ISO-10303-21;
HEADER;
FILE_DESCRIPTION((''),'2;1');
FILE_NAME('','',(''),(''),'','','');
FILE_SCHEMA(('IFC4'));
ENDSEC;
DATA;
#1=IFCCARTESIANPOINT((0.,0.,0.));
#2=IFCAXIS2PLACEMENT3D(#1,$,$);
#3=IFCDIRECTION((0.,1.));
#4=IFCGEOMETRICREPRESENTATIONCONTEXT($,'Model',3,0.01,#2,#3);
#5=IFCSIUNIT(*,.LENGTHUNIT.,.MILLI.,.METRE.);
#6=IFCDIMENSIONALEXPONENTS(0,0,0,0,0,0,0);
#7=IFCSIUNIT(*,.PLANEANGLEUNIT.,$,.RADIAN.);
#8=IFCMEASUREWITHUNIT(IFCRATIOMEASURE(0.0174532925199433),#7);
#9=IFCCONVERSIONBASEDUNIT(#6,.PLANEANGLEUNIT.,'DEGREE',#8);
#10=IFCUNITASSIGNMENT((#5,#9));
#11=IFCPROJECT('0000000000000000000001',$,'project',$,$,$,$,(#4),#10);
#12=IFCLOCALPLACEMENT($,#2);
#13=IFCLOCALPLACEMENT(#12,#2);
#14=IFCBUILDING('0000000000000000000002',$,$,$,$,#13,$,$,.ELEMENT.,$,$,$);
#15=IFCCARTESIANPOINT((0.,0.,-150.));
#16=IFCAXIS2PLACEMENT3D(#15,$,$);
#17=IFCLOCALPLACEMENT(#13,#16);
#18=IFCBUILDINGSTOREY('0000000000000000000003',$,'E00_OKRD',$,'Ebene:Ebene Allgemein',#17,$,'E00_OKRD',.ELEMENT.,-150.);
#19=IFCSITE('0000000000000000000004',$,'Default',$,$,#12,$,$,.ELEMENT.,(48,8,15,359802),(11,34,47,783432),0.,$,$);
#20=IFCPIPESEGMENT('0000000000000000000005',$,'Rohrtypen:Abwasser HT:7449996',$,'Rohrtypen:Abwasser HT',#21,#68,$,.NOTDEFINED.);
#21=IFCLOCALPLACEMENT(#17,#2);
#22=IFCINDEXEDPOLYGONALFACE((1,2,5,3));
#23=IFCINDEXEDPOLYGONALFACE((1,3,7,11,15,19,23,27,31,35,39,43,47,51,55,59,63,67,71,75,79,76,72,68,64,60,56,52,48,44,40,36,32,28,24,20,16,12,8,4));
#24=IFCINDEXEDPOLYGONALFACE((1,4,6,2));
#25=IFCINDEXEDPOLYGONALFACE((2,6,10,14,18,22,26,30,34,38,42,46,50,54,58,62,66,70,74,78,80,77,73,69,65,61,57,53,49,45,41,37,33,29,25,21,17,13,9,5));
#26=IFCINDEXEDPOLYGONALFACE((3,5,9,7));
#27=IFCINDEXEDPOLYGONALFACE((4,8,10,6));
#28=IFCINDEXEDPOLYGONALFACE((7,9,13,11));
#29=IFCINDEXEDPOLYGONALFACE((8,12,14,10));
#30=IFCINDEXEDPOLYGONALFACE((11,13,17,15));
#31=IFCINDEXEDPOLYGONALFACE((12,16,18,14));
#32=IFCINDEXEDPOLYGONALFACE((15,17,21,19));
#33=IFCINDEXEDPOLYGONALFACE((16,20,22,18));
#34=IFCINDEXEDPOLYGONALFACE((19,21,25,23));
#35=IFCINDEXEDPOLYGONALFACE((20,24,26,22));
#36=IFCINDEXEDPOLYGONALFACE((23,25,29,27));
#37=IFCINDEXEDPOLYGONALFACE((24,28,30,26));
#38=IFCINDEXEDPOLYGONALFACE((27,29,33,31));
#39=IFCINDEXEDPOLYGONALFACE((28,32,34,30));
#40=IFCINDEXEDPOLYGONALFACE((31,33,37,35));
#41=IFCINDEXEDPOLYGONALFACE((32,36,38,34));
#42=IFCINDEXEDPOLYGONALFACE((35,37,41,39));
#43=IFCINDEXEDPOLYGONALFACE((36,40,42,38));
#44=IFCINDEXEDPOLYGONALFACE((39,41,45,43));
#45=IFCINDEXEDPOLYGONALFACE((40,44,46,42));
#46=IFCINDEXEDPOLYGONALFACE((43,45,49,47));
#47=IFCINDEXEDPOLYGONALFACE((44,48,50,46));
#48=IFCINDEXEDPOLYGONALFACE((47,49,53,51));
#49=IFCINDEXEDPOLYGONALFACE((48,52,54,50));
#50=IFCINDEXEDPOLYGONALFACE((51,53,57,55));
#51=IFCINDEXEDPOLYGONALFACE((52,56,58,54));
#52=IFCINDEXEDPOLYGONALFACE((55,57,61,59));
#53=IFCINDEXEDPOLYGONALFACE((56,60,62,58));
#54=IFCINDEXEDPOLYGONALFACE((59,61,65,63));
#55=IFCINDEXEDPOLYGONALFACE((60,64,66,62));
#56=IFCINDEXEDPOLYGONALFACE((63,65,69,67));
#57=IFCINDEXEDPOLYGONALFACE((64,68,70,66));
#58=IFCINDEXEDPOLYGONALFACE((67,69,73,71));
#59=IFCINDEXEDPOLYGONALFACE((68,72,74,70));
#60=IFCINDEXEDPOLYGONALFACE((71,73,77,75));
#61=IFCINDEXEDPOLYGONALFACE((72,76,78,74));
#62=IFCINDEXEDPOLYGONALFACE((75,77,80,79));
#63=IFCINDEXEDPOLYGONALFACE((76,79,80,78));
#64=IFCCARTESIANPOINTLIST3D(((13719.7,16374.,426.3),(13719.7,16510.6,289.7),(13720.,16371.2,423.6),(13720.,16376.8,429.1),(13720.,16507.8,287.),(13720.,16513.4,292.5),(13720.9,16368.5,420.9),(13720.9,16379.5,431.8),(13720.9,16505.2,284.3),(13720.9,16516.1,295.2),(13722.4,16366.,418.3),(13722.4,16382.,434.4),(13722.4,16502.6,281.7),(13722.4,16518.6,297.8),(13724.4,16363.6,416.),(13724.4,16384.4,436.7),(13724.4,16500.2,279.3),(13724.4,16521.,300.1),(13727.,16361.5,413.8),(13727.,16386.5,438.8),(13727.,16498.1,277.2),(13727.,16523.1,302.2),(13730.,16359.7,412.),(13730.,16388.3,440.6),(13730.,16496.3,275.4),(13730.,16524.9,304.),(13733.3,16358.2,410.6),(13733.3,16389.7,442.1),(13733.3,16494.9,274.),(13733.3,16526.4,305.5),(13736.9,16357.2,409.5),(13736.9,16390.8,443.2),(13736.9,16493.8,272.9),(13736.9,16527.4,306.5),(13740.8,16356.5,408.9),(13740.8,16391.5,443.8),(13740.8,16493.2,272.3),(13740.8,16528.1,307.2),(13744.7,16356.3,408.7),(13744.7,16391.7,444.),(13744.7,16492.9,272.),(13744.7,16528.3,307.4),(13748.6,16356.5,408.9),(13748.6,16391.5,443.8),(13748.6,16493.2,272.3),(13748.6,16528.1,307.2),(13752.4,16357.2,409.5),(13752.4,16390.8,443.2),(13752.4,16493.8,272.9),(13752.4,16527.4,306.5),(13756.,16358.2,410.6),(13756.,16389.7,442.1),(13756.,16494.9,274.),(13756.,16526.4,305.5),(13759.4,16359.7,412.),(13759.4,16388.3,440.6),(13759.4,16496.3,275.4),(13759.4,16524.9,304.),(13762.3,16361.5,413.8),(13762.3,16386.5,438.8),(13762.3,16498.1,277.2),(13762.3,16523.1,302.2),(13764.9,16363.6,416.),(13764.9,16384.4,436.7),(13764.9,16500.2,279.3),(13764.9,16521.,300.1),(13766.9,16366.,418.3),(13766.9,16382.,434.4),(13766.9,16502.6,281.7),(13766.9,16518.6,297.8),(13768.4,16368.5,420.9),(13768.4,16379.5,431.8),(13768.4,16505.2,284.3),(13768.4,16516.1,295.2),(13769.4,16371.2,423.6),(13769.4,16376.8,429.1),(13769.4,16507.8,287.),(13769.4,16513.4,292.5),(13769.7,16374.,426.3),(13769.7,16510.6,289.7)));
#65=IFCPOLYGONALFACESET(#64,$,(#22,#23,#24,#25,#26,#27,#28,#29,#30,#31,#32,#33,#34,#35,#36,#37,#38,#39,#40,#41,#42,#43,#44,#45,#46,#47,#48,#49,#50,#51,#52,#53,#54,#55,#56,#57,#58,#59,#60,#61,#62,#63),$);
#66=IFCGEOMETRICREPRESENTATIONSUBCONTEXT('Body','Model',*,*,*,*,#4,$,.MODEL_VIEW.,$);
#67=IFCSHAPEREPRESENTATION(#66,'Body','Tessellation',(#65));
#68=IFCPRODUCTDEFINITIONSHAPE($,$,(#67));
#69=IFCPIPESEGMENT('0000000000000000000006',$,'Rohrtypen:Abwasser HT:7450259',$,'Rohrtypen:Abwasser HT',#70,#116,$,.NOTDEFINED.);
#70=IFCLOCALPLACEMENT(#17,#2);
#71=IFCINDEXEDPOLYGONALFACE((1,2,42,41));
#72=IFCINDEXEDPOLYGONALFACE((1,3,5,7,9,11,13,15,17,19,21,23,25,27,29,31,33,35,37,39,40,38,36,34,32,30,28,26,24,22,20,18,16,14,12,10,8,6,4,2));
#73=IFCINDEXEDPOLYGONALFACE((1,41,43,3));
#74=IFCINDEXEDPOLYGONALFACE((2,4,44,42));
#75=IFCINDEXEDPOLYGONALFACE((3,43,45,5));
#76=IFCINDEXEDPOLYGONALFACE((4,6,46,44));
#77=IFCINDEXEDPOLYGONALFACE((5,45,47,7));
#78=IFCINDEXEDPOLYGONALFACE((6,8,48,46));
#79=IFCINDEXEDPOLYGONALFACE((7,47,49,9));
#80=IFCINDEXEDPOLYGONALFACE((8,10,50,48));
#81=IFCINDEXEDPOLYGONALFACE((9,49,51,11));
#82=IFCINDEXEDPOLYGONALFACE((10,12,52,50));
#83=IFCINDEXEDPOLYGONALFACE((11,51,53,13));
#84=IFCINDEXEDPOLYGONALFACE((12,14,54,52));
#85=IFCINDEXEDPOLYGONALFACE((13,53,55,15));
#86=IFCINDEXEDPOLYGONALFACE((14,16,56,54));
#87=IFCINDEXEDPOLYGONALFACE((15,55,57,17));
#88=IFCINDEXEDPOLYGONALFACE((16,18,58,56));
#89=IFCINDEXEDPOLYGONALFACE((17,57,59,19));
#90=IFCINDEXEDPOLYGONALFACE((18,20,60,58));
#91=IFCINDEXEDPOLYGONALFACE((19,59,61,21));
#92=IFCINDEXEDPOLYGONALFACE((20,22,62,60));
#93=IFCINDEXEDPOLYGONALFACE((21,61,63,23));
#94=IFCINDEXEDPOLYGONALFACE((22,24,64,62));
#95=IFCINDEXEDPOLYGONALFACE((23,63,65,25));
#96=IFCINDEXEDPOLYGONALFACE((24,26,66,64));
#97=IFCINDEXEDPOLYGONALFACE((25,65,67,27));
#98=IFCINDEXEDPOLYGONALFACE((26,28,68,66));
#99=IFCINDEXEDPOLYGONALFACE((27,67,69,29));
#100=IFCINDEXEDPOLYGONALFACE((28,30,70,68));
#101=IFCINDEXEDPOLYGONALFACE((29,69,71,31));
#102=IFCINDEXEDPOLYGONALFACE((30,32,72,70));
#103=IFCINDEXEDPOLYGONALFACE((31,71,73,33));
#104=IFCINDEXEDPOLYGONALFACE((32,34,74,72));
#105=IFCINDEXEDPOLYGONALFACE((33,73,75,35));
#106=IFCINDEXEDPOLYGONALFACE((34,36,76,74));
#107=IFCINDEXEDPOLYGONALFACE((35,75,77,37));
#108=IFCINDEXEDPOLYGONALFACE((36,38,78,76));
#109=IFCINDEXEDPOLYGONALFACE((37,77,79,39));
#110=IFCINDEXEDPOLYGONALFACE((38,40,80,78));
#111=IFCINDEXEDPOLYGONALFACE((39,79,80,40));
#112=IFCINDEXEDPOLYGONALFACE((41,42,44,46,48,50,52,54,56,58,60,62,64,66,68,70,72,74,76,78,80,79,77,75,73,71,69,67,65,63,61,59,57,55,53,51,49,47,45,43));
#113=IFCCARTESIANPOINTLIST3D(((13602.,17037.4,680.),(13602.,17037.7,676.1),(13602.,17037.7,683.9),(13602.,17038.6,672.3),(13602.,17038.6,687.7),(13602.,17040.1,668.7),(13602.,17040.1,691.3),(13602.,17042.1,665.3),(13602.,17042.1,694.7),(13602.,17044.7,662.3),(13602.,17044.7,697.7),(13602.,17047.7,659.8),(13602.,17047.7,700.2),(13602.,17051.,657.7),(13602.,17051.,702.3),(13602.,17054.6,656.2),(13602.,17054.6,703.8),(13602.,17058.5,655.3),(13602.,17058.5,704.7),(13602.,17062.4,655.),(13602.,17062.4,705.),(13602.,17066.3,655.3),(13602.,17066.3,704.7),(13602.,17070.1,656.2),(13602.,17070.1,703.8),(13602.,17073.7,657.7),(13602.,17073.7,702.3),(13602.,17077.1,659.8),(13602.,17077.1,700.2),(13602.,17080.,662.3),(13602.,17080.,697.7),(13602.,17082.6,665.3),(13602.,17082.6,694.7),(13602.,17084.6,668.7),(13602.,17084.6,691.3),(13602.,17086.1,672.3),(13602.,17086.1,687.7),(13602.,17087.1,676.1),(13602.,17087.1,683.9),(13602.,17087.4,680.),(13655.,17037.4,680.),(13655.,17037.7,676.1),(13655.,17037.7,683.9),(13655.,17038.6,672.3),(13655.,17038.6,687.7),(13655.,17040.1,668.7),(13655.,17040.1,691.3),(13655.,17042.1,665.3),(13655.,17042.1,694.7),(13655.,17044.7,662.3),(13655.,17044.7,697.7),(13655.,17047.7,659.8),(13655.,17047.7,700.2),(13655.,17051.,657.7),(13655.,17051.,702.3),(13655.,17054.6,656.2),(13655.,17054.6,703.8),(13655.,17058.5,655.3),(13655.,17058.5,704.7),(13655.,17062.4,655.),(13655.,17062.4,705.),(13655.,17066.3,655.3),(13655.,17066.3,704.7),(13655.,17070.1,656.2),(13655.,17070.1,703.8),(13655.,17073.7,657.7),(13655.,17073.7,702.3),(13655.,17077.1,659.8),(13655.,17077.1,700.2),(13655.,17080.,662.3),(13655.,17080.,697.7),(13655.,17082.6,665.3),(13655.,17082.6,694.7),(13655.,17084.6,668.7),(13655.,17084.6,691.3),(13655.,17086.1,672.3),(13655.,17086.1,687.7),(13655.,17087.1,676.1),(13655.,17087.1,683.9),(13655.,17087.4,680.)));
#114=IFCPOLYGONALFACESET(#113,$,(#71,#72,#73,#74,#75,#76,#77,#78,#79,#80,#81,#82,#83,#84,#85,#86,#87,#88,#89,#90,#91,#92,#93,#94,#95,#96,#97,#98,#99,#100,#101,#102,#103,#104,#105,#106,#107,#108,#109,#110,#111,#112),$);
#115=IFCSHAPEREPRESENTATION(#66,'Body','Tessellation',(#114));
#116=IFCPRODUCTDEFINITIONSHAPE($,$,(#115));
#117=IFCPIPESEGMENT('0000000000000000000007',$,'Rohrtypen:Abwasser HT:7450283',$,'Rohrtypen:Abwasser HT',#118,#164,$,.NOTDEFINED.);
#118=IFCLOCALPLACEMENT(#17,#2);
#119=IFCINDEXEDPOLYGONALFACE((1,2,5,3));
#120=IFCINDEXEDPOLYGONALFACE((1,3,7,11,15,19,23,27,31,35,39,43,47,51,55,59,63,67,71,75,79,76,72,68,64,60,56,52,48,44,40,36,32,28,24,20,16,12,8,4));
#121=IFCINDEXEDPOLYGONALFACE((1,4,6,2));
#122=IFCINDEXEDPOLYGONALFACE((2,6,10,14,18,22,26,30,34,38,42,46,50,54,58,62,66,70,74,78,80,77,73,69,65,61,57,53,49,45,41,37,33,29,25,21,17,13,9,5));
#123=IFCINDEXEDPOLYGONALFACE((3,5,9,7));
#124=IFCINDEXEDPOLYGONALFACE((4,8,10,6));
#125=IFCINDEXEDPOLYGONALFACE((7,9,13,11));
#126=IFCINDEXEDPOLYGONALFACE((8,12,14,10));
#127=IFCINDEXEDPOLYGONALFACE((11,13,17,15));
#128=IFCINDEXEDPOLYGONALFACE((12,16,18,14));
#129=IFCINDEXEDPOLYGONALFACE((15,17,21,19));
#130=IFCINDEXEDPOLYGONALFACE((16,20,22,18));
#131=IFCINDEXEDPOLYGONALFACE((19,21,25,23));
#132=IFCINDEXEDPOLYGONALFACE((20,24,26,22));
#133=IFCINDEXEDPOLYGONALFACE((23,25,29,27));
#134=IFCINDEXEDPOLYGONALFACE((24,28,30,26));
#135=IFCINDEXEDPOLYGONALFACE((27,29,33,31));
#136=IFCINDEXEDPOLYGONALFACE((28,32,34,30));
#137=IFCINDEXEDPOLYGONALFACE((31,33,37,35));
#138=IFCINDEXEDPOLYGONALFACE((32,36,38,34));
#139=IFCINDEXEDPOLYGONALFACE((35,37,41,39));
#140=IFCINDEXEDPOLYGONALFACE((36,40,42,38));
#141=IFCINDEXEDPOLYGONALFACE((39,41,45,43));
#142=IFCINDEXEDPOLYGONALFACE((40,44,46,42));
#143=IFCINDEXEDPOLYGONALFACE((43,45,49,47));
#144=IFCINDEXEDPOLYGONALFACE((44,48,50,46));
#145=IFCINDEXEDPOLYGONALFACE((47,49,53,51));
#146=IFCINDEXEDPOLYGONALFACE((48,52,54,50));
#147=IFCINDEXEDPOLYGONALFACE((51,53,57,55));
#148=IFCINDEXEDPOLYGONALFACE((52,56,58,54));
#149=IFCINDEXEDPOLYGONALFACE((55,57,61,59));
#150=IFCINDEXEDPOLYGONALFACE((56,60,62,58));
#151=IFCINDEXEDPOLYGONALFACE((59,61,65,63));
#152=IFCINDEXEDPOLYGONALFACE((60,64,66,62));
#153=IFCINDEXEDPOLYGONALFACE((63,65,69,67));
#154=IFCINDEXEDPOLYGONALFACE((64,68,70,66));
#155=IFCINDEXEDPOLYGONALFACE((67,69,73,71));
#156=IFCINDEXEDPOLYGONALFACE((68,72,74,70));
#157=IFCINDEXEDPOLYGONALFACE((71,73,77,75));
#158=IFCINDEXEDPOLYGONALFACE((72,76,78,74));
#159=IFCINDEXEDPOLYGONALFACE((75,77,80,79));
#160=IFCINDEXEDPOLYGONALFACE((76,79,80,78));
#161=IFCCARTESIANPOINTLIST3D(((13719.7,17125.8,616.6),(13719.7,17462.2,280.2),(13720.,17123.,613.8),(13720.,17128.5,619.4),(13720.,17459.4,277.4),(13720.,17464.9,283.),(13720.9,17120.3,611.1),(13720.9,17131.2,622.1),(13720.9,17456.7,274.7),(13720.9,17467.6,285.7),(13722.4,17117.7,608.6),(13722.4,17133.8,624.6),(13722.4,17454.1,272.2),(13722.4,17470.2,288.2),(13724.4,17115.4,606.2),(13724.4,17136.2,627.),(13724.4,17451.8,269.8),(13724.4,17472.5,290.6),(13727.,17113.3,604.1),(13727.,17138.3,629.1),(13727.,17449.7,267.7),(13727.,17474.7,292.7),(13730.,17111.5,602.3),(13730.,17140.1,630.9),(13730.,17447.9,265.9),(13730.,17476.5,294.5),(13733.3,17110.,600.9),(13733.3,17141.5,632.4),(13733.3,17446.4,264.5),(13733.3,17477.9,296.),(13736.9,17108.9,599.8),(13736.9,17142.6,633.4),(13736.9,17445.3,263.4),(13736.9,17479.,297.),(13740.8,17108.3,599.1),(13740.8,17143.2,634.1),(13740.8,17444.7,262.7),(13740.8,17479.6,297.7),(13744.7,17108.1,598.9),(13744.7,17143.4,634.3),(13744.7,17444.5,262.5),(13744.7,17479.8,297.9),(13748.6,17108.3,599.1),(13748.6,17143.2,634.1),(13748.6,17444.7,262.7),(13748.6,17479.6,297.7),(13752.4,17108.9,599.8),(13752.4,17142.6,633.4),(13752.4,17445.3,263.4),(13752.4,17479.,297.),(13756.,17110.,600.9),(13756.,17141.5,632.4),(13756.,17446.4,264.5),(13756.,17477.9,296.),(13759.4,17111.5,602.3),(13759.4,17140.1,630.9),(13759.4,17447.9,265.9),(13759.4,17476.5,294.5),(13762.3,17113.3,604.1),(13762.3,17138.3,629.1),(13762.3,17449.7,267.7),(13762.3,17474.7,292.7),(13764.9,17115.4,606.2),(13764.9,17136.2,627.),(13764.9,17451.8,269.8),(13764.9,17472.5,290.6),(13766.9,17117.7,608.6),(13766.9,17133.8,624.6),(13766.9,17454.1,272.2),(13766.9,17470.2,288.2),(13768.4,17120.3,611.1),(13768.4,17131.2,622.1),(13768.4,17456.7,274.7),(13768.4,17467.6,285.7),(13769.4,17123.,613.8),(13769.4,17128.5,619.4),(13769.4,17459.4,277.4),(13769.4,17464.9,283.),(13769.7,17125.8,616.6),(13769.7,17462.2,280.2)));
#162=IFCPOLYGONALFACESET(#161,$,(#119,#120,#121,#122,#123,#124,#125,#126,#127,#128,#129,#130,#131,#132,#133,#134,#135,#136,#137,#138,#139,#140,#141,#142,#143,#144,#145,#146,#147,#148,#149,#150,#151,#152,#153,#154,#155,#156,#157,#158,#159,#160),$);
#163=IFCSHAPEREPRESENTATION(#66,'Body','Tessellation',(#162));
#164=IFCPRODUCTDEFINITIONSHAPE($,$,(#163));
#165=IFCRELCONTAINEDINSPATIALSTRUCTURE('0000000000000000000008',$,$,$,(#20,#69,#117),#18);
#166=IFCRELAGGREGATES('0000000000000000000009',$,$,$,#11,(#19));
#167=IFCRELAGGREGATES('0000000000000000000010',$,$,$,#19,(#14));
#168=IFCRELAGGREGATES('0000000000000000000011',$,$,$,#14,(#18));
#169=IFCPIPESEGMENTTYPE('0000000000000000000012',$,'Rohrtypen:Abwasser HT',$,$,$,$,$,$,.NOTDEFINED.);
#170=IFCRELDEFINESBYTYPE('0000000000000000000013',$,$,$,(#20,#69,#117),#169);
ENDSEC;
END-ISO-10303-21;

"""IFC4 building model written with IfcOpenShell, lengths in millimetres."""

from ifc_helpers import new_model, entity, si_unit, converted_unit, direction, frame, origin, place, context, subcontext, project, spatial, indexed_curve, outline, extrude, type_object, element, save


model = new_model("IFC4")

# Units and contexts
model_context = context("Model", 3, precision=0.01, world=origin(), true_north=direction((0.0, 1.0)))
body_context = subcontext(model_context, "Body", "Model", "MODEL_VIEW")
ifc_project = project(units=[si_unit("LENGTHUNIT", "METRE", prefix="MILLI"), converted_unit("PLANEANGLEUNIT", "DEGREE", entity("IfcRatioMeasure", 0.0174532925199433), si_unit("PLANEANGLEUNIT", "RADIAN"), dimensions=[0, 0, 0, 0, 0, 0, 0])], contexts=[model_context])

# Site, building, storey
site_placement = place(None, origin())
site = spatial("IfcSite", under=ifc_project, at=site_placement, Name="Default", CompositionType="ELEMENT", RefLatitude=(48, 8, 15, 359802), RefLongitude=(11, 34, 47, 783432), RefElevation=0.0)
building_placement = place(site_placement, origin())
building = spatial("IfcBuilding", under=site, at=building_placement, CompositionType="ELEMENT")
storey_placement = place(building_placement, frame((0.0, 0.0, -150.0)))
storey = spatial("IfcBuildingStorey", under=building, at=storey_placement, Name="E00_OKRD", ObjectType="Ebene:Ebene Allgemein", LongName="E00_OKRD", CompositionType="ELEMENT", Elevation=-150.0)

# Pipe segments
pipe_segment_type_1 = type_object("IfcPipeSegmentType", Name="Rohrtypen:Abwasser HT", PredefinedType="NOTDEFINED")
pipe_segment_1_placement = place(storey_placement, origin())
element("IfcPipeSegment", 1, at=pipe_segment_1_placement, inside=storey, type_object=pipe_segment_type_1, Name="Rohrtypen:Abwasser HT:7449996", ObjectType="Rohrtypen:Abwasser HT", PredefinedType="NOTDEFINED", context=body_context, shape_type="SweptSolid", body=[
    extrude(outline(indexed_curve([(25.0, 0.0), (24.7, 3.9), (23.8, 7.7), (22.3, 11.3), (20.2, 14.7), (17.7, 17.7), (14.7, 20.2), (11.3, 22.3), (7.7, 23.8), (3.9, 24.7), (0.0, 25.0), (-3.9, 24.7), (-7.7, 23.8), (-11.3, 22.3), (-14.7, 20.2), (-17.7, 17.7), (-20.2, 14.7), (-22.3, 11.3), (-23.8, 7.7), (-24.7, 3.9), (-25.0, 0.0), (-24.7, -3.9), (-23.8, -7.7), (-22.3, -11.3), (-20.2, -14.7), (-17.7, -17.7), (-14.7, -20.2), (-11.3, -22.3), (-7.7, -23.8), (-3.9, -24.7), (0.0, -25.0), (3.9, -24.7), (7.7, -23.8), (11.3, -22.3), (14.7, -20.2), (17.7, -17.7), (20.2, -14.7), (22.3, -11.3), (23.8, -7.7), (24.7, -3.9), (25.0, 0.0)], self_intersect=False)), frame((13744.7, 16374.0, 426.3), z_axis=(0.0, 0.707107, -0.707107), x_axis=(1.0, 0.0, 0.0)), (0.0, 0.0, 1.0), 193.2),
])
pipe_segment_2_placement = place(storey_placement, origin())
element("IfcPipeSegment", 2, at=pipe_segment_2_placement, inside=storey, type_object=pipe_segment_type_1, Name="Rohrtypen:Abwasser HT:7450259", ObjectType="Rohrtypen:Abwasser HT", PredefinedType="NOTDEFINED", context=body_context, shape_type="SweptSolid", body=[
    extrude(outline(indexed_curve([(25.0, 0.0), (24.7, 3.9), (23.8, 7.7), (22.3, 11.3), (20.2, 14.7), (17.7, 17.7), (14.7, 20.2), (11.3, 22.3), (7.7, 23.8), (3.9, 24.7), (0.0, 25.0), (-3.9, 24.7), (-7.7, 23.8), (-11.3, 22.3), (-14.7, 20.2), (-17.7, 17.7), (-20.2, 14.7), (-22.3, 11.3), (-23.8, 7.7), (-24.7, 3.9), (-25.0, 0.0), (-24.7, -3.9), (-23.8, -7.7), (-22.3, -11.3), (-20.2, -14.7), (-17.7, -17.7), (-14.7, -20.2), (-11.3, -22.3), (-7.7, -23.8), (-3.9, -24.7), (0.0, -25.0), (3.9, -24.7), (7.7, -23.8), (11.3, -22.3), (14.7, -20.2), (17.7, -17.7), (20.2, -14.7), (22.3, -11.3), (23.8, -7.7), (24.7, -3.9), (25.0, 0.0)], self_intersect=False)), frame((13602.0, 17062.4, 680.0), z_axis=(1.0, 0.0, 0.0), x_axis=(0.0, -1.0, 0.0)), (0.0, 0.0, 1.0), 53.1),
])
pipe_segment_3_placement = place(storey_placement, origin())
element("IfcPipeSegment", 3, at=pipe_segment_3_placement, inside=storey, type_object=pipe_segment_type_1, Name="Rohrtypen:Abwasser HT:7450283", ObjectType="Rohrtypen:Abwasser HT", PredefinedType="NOTDEFINED", context=body_context, shape_type="SweptSolid", body=[
    extrude(outline(indexed_curve([(25.0, 0.0), (24.7, 3.9), (23.8, 7.7), (22.3, 11.3), (20.2, 14.7), (17.7, 17.7), (14.7, 20.2), (11.3, 22.3), (7.7, 23.8), (3.9, 24.7), (0.0, 25.0), (-3.9, 24.7), (-7.7, 23.8), (-11.3, 22.3), (-14.7, 20.2), (-17.7, 17.7), (-20.2, 14.7), (-22.3, 11.3), (-23.8, 7.7), (-24.7, 3.9), (-25.0, 0.0), (-24.7, -3.9), (-23.8, -7.7), (-22.3, -11.3), (-20.2, -14.7), (-17.7, -17.7), (-14.7, -20.2), (-11.3, -22.3), (-7.7, -23.8), (-3.9, -24.7), (0.0, -25.0), (3.9, -24.7), (7.7, -23.8), (11.3, -22.3), (14.7, -20.2), (17.7, -17.7), (20.2, -14.7), (22.3, -11.3), (23.8, -7.7), (24.7, -3.9), (25.0, 0.0)], self_intersect=False)), frame((13744.7, 17125.8, 616.6), z_axis=(0.0, 0.707107, -0.707107), x_axis=(1.0, 0.0, 0.0)), (0.0, 0.0, 1.0), 475.7),
])

save(model, "model.ifc")
